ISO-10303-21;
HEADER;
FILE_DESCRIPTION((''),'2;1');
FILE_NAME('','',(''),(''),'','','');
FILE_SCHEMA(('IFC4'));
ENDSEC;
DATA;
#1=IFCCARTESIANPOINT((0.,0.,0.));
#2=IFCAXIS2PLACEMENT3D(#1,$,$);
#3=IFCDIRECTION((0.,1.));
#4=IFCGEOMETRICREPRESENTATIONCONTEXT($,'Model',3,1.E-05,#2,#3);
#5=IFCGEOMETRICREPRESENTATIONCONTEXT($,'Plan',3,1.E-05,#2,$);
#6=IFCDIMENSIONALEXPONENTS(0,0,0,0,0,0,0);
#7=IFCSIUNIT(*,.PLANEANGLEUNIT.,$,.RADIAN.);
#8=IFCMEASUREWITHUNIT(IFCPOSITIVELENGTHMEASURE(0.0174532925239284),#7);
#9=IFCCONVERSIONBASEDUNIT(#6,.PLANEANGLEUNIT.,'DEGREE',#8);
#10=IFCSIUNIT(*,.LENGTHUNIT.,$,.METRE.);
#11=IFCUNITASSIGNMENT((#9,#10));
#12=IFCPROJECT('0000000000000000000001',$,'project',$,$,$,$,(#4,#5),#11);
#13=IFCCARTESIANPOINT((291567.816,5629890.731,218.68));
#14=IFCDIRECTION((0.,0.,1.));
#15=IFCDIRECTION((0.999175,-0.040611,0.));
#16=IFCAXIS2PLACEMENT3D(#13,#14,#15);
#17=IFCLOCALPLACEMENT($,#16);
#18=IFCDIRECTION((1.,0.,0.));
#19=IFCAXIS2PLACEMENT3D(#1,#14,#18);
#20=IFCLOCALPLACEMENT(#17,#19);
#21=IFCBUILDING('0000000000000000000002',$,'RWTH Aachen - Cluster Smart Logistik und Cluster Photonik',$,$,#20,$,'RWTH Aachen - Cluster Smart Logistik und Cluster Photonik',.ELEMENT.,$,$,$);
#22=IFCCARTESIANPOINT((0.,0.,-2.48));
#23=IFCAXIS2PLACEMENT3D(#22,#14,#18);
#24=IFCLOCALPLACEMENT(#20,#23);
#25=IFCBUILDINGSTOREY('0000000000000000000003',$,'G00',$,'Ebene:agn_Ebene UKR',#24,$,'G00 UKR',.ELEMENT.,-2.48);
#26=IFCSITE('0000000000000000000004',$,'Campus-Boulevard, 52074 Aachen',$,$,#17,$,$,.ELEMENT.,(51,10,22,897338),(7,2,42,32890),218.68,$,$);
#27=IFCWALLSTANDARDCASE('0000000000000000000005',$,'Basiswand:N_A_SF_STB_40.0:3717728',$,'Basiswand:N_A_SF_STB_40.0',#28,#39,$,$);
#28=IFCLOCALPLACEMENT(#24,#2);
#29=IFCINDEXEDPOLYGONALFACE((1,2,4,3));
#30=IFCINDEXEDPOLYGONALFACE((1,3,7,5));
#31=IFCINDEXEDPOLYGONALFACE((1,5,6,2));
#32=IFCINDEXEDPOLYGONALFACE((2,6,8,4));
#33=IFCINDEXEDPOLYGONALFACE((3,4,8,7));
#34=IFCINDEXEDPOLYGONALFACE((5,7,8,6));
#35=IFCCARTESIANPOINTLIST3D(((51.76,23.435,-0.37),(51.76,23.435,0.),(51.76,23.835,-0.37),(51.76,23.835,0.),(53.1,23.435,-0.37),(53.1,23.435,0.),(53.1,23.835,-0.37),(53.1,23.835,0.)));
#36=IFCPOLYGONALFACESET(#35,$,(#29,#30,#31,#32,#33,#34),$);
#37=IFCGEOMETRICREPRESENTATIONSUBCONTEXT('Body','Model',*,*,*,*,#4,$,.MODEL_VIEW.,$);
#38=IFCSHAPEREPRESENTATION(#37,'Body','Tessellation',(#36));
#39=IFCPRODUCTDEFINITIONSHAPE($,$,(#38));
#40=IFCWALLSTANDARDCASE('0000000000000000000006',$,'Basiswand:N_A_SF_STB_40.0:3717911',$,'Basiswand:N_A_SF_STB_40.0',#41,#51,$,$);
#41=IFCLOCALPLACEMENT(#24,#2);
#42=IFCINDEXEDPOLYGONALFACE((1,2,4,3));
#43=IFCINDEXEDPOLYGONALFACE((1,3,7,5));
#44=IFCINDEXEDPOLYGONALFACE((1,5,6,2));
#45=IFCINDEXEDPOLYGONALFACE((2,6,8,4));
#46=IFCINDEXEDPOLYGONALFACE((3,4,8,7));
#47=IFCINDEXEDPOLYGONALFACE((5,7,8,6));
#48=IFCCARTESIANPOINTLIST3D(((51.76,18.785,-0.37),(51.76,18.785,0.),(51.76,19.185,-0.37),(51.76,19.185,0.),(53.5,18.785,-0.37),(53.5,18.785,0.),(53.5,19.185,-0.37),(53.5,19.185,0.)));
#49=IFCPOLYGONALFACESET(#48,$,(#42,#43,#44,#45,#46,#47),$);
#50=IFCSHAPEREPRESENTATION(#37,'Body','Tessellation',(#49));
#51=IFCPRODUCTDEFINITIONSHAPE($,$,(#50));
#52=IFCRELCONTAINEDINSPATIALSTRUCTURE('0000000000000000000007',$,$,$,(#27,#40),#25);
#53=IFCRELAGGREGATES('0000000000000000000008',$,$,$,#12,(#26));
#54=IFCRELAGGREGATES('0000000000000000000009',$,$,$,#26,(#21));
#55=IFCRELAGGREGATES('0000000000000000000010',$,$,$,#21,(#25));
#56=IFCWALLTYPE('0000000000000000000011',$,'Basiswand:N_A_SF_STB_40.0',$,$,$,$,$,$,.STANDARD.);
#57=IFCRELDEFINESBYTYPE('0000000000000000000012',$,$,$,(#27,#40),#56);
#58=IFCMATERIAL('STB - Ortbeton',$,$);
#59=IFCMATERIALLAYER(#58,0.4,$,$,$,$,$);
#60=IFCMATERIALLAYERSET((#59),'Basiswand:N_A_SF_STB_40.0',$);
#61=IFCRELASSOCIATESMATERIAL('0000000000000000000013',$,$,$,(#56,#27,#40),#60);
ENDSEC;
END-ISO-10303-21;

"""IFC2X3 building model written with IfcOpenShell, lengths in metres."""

from ifc_helpers import new_model, entity, si_unit, converted_unit, direction, frame, frame_2d, origin, origin_with_axes, place, context, subcontext, project, spatial, rectangle, extrude, material, layer, layer_set, layer_usage, type_object, element, save


model = new_model("IFC2X3")

# Units and contexts
model_context = context("Model", 3, precision=1e-05, world=origin(), true_north=direction((0.0, 1.0)))
plan_context = context("Plan", 3, precision=1e-05, world=origin())
body_context = subcontext(model_context, "Body", "Model", "MODEL_VIEW")
ifc_project = project(units=[converted_unit("PLANEANGLEUNIT", "DEGREE", entity("IfcPositiveLengthMeasure", 0.0174532925239284), si_unit("PLANEANGLEUNIT", "RADIAN"), dimensions=[0, 0, 0, 0, 0, 0, 0]), si_unit("LENGTHUNIT", "METRE")], contexts=[model_context, plan_context])

# Site, building, storey
site_placement = place(None, frame((291567.816, 5629890.731, 218.68), z_axis=(0.0, 0.0, 1.0), x_axis=(0.999175, -0.040611, 0.0)))
site = spatial("IfcSite", under=ifc_project, at=site_placement, Name="Campus-Boulevard, 52074 Aachen", CompositionType="ELEMENT", RefLatitude=(51, 10, 22, 897338), RefLongitude=(7, 2, 42, 32890), RefElevation=218.68)
building_placement = place(site_placement, origin_with_axes())
building = spatial("IfcBuilding", under=site, at=building_placement, Name="RWTH Aachen - Cluster Smart Logistik und Cluster Photonik", LongName="RWTH Aachen - Cluster Smart Logistik und Cluster Photonik", CompositionType="ELEMENT")
storey_placement = place(building_placement, frame((0.0, 0.0, -2.48), z_axis=(0.0, 0.0, 1.0), x_axis=(1.0, 0.0, 0.0)))
storey = spatial("IfcBuildingStorey", under=building, at=storey_placement, Name="G00", ObjectType="Ebene:agn_Ebene UKR", LongName="G00 UKR", CompositionType="ELEMENT", Elevation=-2.48)

# Shared definitions
ifc_material_1 = material(Name="STB - Ortbeton")

# Shared definitions
ifc_layer_1 = layer(ifc_material_1, 0.4)
ifc_layer_set_1 = layer_set([ifc_layer_1], Name="Basiswand:N_A_SF_STB_40.0")
wall_type_1 = type_object("IfcWallType", Name="Basiswand:N_A_SF_STB_40.0", PredefinedType="STANDARD", material=ifc_layer_set_1)

# Walls
ifc_layer_usage_1 = layer_usage(ifc_layer_set_1, "AXIS2", "NEGATIVE", 0.2)
wall_1_placement = place(storey_placement, frame((51.76, 23.635, -0.37), z_axis=(0.0, 0.0, 1.0), x_axis=(1.0, 0.0, 0.0)))
element("IfcWallStandardCase", 1, at=wall_1_placement, inside=storey, type_object=wall_type_1, material=ifc_layer_usage_1, Name="Basiswand:N_A_SF_STB_40.0:3717728", ObjectType="Basiswand:N_A_SF_STB_40.0", context=body_context, shape_type="SweptSolid", body=[
    extrude(rectangle(XDim=1.34, YDim=0.4, at=frame_2d((0.67, 0.0), x_axis=(-1.0, 0.0))), origin(), (0.0, 0.0, 1.0), 0.37),
])
ifc_layer_usage_2 = layer_usage(ifc_layer_set_1, "AXIS2", "NEGATIVE", 0.2)
wall_2_placement = place(storey_placement, frame((51.76, 18.985, -0.37), z_axis=(0.0, 0.0, 1.0), x_axis=(1.0, 0.0, 0.0)))
element("IfcWallStandardCase", 2, at=wall_2_placement, inside=storey, type_object=wall_type_1, material=ifc_layer_usage_2, Name="Basiswand:N_A_SF_STB_40.0:3717911", ObjectType="Basiswand:N_A_SF_STB_40.0", context=body_context, shape_type="SweptSolid", body=[
    extrude(rectangle(XDim=1.74, YDim=0.4, at=frame_2d((0.87, 0.0), x_axis=(-1.0, 0.0))), origin(), (0.0, 0.0, 1.0), 0.37),
])

save(model, "model.ifc")
